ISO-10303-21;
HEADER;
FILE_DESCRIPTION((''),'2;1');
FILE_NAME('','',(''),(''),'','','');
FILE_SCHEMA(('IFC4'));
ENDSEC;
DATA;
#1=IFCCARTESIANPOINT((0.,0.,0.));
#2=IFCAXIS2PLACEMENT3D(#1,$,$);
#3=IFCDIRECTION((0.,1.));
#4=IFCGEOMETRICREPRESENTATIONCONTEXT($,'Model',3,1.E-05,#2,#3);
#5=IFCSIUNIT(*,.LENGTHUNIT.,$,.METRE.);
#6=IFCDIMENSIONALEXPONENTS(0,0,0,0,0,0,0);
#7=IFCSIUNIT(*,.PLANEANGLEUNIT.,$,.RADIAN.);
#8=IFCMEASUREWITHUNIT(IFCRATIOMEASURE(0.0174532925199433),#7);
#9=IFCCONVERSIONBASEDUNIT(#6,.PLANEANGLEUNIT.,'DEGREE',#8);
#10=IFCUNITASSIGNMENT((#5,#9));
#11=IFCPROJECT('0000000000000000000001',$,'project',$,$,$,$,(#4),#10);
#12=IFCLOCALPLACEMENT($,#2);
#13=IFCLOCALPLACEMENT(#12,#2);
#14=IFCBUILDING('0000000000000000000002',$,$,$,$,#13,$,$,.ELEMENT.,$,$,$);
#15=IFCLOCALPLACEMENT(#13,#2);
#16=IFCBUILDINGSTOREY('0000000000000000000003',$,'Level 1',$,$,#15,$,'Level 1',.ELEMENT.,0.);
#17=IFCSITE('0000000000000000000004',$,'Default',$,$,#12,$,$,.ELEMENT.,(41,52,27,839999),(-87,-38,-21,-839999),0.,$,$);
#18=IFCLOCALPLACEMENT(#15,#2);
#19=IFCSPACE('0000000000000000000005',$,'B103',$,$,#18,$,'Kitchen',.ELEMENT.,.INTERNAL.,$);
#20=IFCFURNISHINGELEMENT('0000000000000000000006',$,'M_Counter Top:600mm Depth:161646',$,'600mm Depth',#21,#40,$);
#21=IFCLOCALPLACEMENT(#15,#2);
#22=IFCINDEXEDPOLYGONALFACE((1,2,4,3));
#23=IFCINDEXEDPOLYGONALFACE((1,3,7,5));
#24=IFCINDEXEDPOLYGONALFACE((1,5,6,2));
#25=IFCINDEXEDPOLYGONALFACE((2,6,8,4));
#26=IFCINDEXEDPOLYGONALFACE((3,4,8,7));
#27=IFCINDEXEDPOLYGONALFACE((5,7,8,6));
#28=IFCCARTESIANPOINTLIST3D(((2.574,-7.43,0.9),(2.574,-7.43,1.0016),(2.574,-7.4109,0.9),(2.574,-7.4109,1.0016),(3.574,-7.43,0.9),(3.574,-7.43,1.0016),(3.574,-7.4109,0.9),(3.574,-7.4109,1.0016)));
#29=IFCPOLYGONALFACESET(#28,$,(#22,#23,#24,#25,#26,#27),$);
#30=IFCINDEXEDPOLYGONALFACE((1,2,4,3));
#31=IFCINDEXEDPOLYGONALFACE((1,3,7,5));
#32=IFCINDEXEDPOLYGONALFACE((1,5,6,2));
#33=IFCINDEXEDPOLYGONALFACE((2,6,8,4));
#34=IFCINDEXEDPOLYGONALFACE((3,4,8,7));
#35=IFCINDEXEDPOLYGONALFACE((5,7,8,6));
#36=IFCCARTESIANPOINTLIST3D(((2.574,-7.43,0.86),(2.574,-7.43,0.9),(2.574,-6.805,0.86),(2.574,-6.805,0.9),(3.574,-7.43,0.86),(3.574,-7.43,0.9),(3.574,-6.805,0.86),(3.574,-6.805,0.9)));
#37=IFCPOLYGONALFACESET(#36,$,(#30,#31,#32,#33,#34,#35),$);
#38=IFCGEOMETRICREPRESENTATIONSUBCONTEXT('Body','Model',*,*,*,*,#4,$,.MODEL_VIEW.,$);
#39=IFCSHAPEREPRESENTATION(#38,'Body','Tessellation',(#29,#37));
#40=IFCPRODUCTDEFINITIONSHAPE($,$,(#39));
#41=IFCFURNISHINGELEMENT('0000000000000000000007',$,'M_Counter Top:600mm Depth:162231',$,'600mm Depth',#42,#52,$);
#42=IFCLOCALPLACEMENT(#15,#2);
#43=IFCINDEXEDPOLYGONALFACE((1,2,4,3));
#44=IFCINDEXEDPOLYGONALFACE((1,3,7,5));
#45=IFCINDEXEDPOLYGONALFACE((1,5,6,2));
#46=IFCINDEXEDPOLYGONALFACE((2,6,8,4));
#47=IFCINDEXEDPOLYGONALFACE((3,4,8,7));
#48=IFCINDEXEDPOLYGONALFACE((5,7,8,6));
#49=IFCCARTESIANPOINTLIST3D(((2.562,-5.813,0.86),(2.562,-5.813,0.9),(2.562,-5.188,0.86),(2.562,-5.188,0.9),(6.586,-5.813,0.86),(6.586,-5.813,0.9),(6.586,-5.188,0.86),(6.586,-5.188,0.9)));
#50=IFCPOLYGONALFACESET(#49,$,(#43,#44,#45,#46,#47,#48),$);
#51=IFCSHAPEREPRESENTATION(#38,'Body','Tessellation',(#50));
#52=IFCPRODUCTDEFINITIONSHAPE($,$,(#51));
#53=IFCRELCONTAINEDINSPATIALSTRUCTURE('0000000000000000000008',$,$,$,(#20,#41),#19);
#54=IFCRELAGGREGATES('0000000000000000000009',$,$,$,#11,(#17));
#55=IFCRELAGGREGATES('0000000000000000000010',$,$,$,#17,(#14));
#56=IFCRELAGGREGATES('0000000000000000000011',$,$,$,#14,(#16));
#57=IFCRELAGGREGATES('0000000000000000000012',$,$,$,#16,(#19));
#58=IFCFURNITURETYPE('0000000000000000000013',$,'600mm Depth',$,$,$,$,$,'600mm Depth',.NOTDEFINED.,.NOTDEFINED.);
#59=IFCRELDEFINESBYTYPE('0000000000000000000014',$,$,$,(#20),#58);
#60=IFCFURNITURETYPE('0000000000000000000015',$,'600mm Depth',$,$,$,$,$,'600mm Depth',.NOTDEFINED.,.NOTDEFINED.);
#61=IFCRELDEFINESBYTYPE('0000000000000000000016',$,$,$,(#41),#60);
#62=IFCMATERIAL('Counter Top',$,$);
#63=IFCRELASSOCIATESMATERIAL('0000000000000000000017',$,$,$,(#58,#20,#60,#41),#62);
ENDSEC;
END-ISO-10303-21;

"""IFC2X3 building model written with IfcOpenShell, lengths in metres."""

from ifc_helpers import new_model, entity, si_unit, converted_unit, direction, frame, frame_2d, origin, place, context, subcontext, project, spatial, rectangle, extrude, source, transform, mapped, material, type_object, type_shapes, element, save


model = new_model("IFC2X3")

# Units and contexts
model_context = context("Model", 3, precision=1e-05, world=origin(), true_north=direction((0.0, 1.0)))
body_context = subcontext(model_context, "Body", "Model", "MODEL_VIEW")
ifc_project = project(units=[si_unit("LENGTHUNIT", "METRE"), converted_unit("PLANEANGLEUNIT", "DEGREE", entity("IfcRatioMeasure", 0.0174532925199433), si_unit("PLANEANGLEUNIT", "RADIAN"), dimensions=[0, 0, 0, 0, 0, 0, 0])], contexts=[model_context])

# Site, building, storey
site_placement = place(None, origin())
site = spatial("IfcSite", under=ifc_project, at=site_placement, Name="Default", CompositionType="ELEMENT", RefLatitude=(41, 52, 27, 839999), RefLongitude=(-87, -38, -21, -839999), RefElevation=0.0)
building_placement = place(site_placement, origin())
building = spatial("IfcBuilding", under=site, at=building_placement, CompositionType="ELEMENT")
storey_placement = place(building_placement, origin())
storey = spatial("IfcBuildingStorey", under=building, at=storey_placement, Name="Level 1", LongName="Level 1", CompositionType="ELEMENT", Elevation=0.0)

# Shared definitions
space_1_placement = place(storey_placement, origin())
space_1 = spatial("IfcSpace", under=storey, at=space_1_placement, Name="B103", LongName="Kitchen", CompositionType="ELEMENT", InteriorOrExteriorSpace="INTERNAL")

# Shared definitions
ifc_material_1 = material(Name="Counter Top")

# Furnishing elements
furniture_type_1 = type_object("IfcFurnitureType", Name="600mm Depth", ElementType="600mm Depth", material=ifc_material_1)
shared_shape_1 = source(origin(), body_context, "Body", "SweptSolid", [
    extrude(rectangle(XDim=0.0191, YDim=1.0, at=frame_2d((0.0, 0.0), x_axis=(1.0, 0.0))), frame((-0.7005, -0.0095, 0.9), z_axis=(0.0, 0.0, 1.0), x_axis=(0.0, -1.0, 0.0)), (0.0, 0.0, 1.0), 0.1016),
    extrude(rectangle(XDim=1.0, YDim=0.625, at=frame_2d((0.0, 0.0), x_axis=(1.0, 0.0))), frame((-0.7005, -0.3125, 0.86), z_axis=(0.0, 0.0, 1.0), x_axis=(-1.0, 0.0, 0.0)), (0.0, 0.0, 1.0), 0.04),
])
type_shapes(furniture_type_1, [shared_shape_1])
furnishing_1_placement = place(space_1_placement, frame((2.3735, -7.43, 0.0), z_axis=(0.0, 0.0, 1.0), x_axis=(-1.0, 0.0, 0.0)))
element("IfcFurnishingElement", 1, at=furnishing_1_placement, inside=space_1, type_object=furniture_type_1, material=ifc_material_1, Name="M_Counter Top:600mm Depth:161646", ObjectType="600mm Depth", context=body_context, shape_type="MappedRepresentation", body=[
    mapped(shared_shape_1, transform((0.0, 0.0, 0.0), scale=1.0)),
])
furniture_type_2 = type_object("IfcFurnitureType", Name="600mm Depth", ElementType="600mm Depth", material=ifc_material_1)
shared_shape_2 = source(origin(), body_context, "Body", "SweptSolid", [
    extrude(rectangle(XDim=4.024, YDim=0.625, at=frame_2d((0.0, 0.0), x_axis=(1.0, 0.0))), frame((0.8115, -0.3125, 0.86), z_axis=(0.0, 0.0, 1.0), x_axis=(-1.0, 0.0, 0.0)), (0.0, 0.0, 1.0), 0.04),
])
type_shapes(furniture_type_2, [shared_shape_2])
furnishing_2_placement = place(space_1_placement, frame((3.7625, -5.188, 0.0)))
element("IfcFurnishingElement", 2, at=furnishing_2_placement, inside=space_1, type_object=furniture_type_2, material=ifc_material_1, Name="M_Counter Top:600mm Depth:162231", ObjectType="600mm Depth", context=body_context, shape_type="MappedRepresentation", body=[
    mapped(shared_shape_2, transform((0.0, 0.0, 0.0), scale=1.0)),
])

save(model, "model.ifc")
